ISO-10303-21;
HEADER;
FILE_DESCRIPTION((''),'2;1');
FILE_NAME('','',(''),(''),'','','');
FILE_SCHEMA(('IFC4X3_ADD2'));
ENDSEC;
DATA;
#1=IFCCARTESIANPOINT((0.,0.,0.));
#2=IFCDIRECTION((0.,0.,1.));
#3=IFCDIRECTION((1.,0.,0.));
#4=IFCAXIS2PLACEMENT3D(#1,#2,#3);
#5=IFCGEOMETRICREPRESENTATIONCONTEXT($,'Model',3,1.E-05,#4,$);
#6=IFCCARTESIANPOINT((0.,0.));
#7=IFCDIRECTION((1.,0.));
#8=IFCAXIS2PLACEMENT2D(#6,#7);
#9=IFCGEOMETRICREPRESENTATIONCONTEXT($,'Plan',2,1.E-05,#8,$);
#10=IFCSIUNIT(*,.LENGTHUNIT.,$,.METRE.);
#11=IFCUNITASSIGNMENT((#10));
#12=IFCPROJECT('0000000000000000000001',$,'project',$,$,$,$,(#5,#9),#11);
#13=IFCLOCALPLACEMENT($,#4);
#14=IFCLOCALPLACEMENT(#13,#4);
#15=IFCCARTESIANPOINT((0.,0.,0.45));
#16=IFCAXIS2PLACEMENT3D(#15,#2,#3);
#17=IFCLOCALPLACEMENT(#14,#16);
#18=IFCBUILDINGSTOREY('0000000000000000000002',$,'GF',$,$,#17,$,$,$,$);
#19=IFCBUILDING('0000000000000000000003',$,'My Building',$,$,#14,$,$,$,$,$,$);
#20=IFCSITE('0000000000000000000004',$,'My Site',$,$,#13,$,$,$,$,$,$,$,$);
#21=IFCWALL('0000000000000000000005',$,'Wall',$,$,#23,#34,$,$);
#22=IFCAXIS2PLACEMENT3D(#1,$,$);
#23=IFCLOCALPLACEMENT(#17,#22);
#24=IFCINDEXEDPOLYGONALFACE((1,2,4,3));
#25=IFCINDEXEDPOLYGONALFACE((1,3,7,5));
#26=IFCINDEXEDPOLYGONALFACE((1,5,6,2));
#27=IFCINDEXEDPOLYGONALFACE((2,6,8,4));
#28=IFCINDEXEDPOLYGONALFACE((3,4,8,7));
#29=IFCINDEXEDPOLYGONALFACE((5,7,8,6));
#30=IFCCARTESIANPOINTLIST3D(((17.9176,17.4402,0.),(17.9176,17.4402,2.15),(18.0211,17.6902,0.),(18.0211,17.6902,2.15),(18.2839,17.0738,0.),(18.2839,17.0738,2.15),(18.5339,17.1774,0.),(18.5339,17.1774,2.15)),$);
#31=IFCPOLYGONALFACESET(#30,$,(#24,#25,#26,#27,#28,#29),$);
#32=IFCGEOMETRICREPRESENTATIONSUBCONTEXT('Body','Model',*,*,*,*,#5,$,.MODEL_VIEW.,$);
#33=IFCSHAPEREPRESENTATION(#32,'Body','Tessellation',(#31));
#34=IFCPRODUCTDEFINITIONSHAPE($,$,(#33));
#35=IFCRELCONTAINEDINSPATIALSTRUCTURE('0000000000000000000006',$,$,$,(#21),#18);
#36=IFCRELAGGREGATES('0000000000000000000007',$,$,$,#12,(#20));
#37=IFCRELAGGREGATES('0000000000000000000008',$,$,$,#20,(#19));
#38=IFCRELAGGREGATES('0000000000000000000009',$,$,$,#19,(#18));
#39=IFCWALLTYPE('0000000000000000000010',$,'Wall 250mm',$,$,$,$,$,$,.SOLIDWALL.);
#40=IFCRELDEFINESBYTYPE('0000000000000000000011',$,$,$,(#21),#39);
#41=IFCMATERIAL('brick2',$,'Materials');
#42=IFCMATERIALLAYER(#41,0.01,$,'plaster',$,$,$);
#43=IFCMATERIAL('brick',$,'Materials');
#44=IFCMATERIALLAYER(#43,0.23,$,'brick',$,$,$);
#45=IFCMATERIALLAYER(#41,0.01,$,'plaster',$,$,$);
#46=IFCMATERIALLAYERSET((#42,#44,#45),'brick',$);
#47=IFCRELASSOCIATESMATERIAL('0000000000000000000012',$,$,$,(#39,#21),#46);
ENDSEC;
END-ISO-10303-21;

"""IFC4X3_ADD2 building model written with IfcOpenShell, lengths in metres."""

from ifc_helpers import new_model, si_unit, frame, origin_with_axes, origin_2d_with_axis, place, context, subcontext, project, spatial, line, indexed_curve, outline, extrude, material, layer, layer_set, layer_usage, type_object, element, save


model = new_model("IFC4X3_ADD2")

# Units and contexts
model_context = context("Model", 3, precision=1e-05, world=origin_with_axes())
plan_context = context("Plan", 2, precision=1e-05, world=origin_2d_with_axis())
body_context_1 = subcontext(model_context, "Body", "Model", "MODEL_VIEW")
ifc_project = project(units=[si_unit("LENGTHUNIT", "METRE")], contexts=[model_context, plan_context])

# Site, building, storey
site_placement = place(None, origin_with_axes())
site = spatial("IfcSite", under=ifc_project, at=site_placement, Name="My Site")
building_placement = place(site_placement, origin_with_axes())
building = spatial("IfcBuilding", under=site, at=building_placement, Name="My Building")
storey_placement = place(building_placement, frame((0.0, 0.0, 0.45), z_axis=(0.0, 0.0, 1.0), x_axis=(1.0, 0.0, 0.0)))
storey = spatial("IfcBuildingStorey", under=building, at=storey_placement, Name="GF")

# Shared definitions
ifc_material_1 = material(Name="brick2", Category="Materials")
ifc_layer_1 = layer(ifc_material_1, 0.01, Name="plaster")
ifc_material_2 = material(Name="brick", Category="Materials")
ifc_layer_2 = layer(ifc_material_2, 0.23, Name="brick")
ifc_layer_3 = layer(ifc_material_1, 0.01, Name="plaster")
ifc_layer_set_1 = layer_set([ifc_layer_1, ifc_layer_2, ifc_layer_3], Name="brick")
wall_type = type_object("IfcWallType", Name="Wall 250mm", PredefinedType="SOLIDWALL", material=ifc_layer_set_1)

# Wall
ifc_layer_usage_1 = layer_usage(ifc_layer_set_1, "AXIS2", "NEGATIVE", 0.0)
wall_1_placement = place(storey_placement, frame((18.2839, 17.0738, 0.0), z_axis=(0.0, 0.0, 1.0), x_axis=(-0.707107, 0.707107, 0.0)))
element("IfcWall", 1, at=wall_1_placement, inside=storey, type_object=wall_type, material=ifc_layer_usage_1, Name="Wall", context=body_context_1, shape_type="SweptSolid", body=[
    extrude(outline(indexed_curve([(-0.1036, -0.25), (0.0, 0.0), (0.5181, 0.0), (0.6217, -0.25)], segments=[line(1, 2, 3, 4, 1)])), origin_with_axes(), (0.0, 0.0, 1.0), 2.15),
])

save(model, "model.ifc")
